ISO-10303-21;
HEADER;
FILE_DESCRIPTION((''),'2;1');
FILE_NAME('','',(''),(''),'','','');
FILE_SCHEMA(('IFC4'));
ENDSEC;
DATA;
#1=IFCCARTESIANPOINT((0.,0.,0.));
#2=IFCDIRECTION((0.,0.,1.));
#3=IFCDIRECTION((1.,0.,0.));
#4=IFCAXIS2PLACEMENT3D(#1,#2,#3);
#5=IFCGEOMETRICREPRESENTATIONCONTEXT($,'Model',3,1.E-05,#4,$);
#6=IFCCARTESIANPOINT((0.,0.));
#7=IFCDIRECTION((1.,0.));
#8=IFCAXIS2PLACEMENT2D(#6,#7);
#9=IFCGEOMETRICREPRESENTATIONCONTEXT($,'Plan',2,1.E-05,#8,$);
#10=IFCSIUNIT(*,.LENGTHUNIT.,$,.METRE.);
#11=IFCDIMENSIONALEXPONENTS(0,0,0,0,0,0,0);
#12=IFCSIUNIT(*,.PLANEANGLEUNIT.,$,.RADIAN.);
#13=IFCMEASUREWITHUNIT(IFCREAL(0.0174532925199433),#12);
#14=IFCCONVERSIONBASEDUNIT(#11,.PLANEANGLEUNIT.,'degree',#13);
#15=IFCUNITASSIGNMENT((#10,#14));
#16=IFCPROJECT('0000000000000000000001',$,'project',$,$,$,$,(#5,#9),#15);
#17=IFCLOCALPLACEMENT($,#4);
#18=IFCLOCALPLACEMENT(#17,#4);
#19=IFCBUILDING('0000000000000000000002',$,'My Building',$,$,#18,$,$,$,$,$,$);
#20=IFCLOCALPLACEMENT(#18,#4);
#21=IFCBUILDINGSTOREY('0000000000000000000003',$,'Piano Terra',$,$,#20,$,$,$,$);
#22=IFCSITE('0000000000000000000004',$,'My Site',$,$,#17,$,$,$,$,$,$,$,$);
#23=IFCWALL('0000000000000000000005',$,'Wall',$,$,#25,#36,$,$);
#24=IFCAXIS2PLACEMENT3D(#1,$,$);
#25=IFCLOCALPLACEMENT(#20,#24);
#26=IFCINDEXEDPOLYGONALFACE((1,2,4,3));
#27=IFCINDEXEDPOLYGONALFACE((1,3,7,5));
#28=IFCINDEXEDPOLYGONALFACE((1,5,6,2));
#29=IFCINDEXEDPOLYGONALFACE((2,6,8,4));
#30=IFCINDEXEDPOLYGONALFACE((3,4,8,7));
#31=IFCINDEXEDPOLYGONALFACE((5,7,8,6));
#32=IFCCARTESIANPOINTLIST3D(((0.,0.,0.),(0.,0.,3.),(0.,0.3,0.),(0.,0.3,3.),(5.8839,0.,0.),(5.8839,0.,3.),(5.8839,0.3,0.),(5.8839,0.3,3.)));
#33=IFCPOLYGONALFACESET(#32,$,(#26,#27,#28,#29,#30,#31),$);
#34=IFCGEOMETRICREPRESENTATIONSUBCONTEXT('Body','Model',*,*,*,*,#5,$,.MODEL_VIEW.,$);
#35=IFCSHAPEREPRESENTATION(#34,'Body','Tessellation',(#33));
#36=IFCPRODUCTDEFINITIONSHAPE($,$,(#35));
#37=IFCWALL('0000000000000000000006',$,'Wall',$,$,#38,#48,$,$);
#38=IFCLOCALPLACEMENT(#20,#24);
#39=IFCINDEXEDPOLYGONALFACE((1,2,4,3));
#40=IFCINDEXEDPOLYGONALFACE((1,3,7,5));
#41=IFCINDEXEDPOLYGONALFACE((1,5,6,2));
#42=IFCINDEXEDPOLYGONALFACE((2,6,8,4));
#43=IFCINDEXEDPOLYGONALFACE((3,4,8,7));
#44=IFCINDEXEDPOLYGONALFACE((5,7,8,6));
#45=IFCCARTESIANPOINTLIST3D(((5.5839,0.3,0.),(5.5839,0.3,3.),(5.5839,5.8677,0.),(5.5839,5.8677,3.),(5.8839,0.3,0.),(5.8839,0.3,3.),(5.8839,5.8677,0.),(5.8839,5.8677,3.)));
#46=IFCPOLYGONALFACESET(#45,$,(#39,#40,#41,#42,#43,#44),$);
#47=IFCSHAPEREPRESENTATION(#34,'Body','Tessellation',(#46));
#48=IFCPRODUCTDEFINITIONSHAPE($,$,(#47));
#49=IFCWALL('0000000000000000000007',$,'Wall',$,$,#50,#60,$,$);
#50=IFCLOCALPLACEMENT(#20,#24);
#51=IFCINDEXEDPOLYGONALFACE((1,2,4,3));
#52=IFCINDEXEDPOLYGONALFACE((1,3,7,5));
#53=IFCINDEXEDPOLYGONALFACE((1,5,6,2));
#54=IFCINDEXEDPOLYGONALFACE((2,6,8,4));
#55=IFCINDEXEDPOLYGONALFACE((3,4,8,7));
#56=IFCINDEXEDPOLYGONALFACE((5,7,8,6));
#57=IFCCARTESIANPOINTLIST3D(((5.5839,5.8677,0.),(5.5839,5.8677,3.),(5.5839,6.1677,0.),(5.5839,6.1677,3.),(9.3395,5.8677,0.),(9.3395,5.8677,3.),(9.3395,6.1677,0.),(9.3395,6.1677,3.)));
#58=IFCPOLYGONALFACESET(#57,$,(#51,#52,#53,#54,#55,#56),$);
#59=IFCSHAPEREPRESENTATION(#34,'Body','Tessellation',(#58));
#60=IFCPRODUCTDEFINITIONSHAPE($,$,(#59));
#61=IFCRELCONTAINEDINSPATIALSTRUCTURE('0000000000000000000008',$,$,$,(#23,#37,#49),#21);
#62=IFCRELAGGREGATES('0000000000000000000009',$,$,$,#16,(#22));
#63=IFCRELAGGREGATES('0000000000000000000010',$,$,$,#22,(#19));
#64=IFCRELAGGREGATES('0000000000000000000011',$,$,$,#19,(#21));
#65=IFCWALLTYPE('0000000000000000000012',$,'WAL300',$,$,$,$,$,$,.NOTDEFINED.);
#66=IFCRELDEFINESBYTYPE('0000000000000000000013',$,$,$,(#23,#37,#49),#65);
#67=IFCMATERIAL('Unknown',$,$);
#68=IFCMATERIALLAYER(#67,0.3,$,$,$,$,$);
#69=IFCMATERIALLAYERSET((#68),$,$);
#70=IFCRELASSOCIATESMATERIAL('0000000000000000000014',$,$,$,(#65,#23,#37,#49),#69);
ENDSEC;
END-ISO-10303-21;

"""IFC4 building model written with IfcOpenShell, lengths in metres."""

from ifc_helpers import new_model, entity, si_unit, converted_unit, frame, origin_with_axes, origin_2d_with_axis, place, context, subcontext, project, spatial, indexed_curve, outline, extrude, material, layer, layer_set, layer_usage, type_object, element, save


model = new_model("IFC4")

# Units and contexts
model_context = context("Model", 3, precision=1e-05, world=origin_with_axes())
plan_context = context("Plan", 2, precision=1e-05, world=origin_2d_with_axis())
body_context = subcontext(model_context, "Body", "Model", "MODEL_VIEW")
ifc_project = project(units=[si_unit("LENGTHUNIT", "METRE"), converted_unit("PLANEANGLEUNIT", "degree", entity("IfcReal", 0.0174532925199433), si_unit("PLANEANGLEUNIT", "RADIAN"), dimensions=[0, 0, 0, 0, 0, 0, 0])], contexts=[model_context, plan_context])

# Site, building, storey
site_placement = place(None, origin_with_axes())
site = spatial("IfcSite", under=ifc_project, at=site_placement, Name="My Site")
building_placement = place(site_placement, origin_with_axes())
building = spatial("IfcBuilding", under=site, at=building_placement, Name="My Building")
storey_placement = place(building_placement, origin_with_axes())
storey = spatial("IfcBuildingStorey", under=building, at=storey_placement, Name="Piano Terra")

# Walls
ifc_material = material(Name="Unknown")
ifc_layer = layer(ifc_material, 0.3)
ifc_layer_set = layer_set([ifc_layer])
ifc_layer_usage_1 = layer_usage(ifc_layer_set, "AXIS2", "POSITIVE", 0.0)
wall_type = type_object("IfcWallType", Name="WAL300", PredefinedType="NOTDEFINED", material=ifc_layer_set)
wall_1_placement = place(storey_placement, origin_with_axes())
element("IfcWall", 1, at=wall_1_placement, inside=storey, type_object=wall_type, material=ifc_layer_usage_1, Name="Wall", context=body_context, shape_type="SweptSolid", body=[
    extrude(outline(indexed_curve([(0.0, 0.0), (0.0, 0.3), (5.8839, 0.3), (5.8839, 0.0), (0.0, 0.0)], self_intersect=False)), origin_with_axes(), (0.0, 0.0, 1.0), 3.0),
])
ifc_layer_usage_2 = layer_usage(ifc_layer_set, "AXIS2", "POSITIVE", 0.0)
wall_2_placement = place(storey_placement, frame((5.8839, 0.3, 0.0), z_axis=(0.0, 0.0, 1.0), x_axis=(0.0, 1.0, 0.0)))
element("IfcWall", 2, at=wall_2_placement, inside=storey, type_object=wall_type, material=ifc_layer_usage_2, Name="Wall", context=body_context, shape_type="SweptSolid", body=[
    extrude(outline(indexed_curve([(0.0, 0.0), (0.0, 0.3), (5.5677, 0.3), (5.5677, 0.0), (0.0, 0.0)], self_intersect=False)), origin_with_axes(), (0.0, 0.0, 1.0), 3.0),
])
ifc_layer_usage_3 = layer_usage(ifc_layer_set, "AXIS2", "POSITIVE", 0.0)
wall_3_placement = place(storey_placement, frame((5.5839, 5.8677, 0.0), z_axis=(0.0, 0.0, 1.0), x_axis=(1.0, -0.000001, 0.0)))
element("IfcWall", 3, at=wall_3_placement, inside=storey, type_object=wall_type, material=ifc_layer_usage_3, Name="Wall", context=body_context, shape_type="SweptSolid", body=[
    extrude(outline(indexed_curve([(0.0, 0.0), (0.0, 0.3), (3.7556, 0.3), (3.7556, 0.0), (0.0, 0.0)], self_intersect=False)), origin_with_axes(), (0.0, 0.0, 1.0), 3.0),
])

save(model, "model.ifc")
